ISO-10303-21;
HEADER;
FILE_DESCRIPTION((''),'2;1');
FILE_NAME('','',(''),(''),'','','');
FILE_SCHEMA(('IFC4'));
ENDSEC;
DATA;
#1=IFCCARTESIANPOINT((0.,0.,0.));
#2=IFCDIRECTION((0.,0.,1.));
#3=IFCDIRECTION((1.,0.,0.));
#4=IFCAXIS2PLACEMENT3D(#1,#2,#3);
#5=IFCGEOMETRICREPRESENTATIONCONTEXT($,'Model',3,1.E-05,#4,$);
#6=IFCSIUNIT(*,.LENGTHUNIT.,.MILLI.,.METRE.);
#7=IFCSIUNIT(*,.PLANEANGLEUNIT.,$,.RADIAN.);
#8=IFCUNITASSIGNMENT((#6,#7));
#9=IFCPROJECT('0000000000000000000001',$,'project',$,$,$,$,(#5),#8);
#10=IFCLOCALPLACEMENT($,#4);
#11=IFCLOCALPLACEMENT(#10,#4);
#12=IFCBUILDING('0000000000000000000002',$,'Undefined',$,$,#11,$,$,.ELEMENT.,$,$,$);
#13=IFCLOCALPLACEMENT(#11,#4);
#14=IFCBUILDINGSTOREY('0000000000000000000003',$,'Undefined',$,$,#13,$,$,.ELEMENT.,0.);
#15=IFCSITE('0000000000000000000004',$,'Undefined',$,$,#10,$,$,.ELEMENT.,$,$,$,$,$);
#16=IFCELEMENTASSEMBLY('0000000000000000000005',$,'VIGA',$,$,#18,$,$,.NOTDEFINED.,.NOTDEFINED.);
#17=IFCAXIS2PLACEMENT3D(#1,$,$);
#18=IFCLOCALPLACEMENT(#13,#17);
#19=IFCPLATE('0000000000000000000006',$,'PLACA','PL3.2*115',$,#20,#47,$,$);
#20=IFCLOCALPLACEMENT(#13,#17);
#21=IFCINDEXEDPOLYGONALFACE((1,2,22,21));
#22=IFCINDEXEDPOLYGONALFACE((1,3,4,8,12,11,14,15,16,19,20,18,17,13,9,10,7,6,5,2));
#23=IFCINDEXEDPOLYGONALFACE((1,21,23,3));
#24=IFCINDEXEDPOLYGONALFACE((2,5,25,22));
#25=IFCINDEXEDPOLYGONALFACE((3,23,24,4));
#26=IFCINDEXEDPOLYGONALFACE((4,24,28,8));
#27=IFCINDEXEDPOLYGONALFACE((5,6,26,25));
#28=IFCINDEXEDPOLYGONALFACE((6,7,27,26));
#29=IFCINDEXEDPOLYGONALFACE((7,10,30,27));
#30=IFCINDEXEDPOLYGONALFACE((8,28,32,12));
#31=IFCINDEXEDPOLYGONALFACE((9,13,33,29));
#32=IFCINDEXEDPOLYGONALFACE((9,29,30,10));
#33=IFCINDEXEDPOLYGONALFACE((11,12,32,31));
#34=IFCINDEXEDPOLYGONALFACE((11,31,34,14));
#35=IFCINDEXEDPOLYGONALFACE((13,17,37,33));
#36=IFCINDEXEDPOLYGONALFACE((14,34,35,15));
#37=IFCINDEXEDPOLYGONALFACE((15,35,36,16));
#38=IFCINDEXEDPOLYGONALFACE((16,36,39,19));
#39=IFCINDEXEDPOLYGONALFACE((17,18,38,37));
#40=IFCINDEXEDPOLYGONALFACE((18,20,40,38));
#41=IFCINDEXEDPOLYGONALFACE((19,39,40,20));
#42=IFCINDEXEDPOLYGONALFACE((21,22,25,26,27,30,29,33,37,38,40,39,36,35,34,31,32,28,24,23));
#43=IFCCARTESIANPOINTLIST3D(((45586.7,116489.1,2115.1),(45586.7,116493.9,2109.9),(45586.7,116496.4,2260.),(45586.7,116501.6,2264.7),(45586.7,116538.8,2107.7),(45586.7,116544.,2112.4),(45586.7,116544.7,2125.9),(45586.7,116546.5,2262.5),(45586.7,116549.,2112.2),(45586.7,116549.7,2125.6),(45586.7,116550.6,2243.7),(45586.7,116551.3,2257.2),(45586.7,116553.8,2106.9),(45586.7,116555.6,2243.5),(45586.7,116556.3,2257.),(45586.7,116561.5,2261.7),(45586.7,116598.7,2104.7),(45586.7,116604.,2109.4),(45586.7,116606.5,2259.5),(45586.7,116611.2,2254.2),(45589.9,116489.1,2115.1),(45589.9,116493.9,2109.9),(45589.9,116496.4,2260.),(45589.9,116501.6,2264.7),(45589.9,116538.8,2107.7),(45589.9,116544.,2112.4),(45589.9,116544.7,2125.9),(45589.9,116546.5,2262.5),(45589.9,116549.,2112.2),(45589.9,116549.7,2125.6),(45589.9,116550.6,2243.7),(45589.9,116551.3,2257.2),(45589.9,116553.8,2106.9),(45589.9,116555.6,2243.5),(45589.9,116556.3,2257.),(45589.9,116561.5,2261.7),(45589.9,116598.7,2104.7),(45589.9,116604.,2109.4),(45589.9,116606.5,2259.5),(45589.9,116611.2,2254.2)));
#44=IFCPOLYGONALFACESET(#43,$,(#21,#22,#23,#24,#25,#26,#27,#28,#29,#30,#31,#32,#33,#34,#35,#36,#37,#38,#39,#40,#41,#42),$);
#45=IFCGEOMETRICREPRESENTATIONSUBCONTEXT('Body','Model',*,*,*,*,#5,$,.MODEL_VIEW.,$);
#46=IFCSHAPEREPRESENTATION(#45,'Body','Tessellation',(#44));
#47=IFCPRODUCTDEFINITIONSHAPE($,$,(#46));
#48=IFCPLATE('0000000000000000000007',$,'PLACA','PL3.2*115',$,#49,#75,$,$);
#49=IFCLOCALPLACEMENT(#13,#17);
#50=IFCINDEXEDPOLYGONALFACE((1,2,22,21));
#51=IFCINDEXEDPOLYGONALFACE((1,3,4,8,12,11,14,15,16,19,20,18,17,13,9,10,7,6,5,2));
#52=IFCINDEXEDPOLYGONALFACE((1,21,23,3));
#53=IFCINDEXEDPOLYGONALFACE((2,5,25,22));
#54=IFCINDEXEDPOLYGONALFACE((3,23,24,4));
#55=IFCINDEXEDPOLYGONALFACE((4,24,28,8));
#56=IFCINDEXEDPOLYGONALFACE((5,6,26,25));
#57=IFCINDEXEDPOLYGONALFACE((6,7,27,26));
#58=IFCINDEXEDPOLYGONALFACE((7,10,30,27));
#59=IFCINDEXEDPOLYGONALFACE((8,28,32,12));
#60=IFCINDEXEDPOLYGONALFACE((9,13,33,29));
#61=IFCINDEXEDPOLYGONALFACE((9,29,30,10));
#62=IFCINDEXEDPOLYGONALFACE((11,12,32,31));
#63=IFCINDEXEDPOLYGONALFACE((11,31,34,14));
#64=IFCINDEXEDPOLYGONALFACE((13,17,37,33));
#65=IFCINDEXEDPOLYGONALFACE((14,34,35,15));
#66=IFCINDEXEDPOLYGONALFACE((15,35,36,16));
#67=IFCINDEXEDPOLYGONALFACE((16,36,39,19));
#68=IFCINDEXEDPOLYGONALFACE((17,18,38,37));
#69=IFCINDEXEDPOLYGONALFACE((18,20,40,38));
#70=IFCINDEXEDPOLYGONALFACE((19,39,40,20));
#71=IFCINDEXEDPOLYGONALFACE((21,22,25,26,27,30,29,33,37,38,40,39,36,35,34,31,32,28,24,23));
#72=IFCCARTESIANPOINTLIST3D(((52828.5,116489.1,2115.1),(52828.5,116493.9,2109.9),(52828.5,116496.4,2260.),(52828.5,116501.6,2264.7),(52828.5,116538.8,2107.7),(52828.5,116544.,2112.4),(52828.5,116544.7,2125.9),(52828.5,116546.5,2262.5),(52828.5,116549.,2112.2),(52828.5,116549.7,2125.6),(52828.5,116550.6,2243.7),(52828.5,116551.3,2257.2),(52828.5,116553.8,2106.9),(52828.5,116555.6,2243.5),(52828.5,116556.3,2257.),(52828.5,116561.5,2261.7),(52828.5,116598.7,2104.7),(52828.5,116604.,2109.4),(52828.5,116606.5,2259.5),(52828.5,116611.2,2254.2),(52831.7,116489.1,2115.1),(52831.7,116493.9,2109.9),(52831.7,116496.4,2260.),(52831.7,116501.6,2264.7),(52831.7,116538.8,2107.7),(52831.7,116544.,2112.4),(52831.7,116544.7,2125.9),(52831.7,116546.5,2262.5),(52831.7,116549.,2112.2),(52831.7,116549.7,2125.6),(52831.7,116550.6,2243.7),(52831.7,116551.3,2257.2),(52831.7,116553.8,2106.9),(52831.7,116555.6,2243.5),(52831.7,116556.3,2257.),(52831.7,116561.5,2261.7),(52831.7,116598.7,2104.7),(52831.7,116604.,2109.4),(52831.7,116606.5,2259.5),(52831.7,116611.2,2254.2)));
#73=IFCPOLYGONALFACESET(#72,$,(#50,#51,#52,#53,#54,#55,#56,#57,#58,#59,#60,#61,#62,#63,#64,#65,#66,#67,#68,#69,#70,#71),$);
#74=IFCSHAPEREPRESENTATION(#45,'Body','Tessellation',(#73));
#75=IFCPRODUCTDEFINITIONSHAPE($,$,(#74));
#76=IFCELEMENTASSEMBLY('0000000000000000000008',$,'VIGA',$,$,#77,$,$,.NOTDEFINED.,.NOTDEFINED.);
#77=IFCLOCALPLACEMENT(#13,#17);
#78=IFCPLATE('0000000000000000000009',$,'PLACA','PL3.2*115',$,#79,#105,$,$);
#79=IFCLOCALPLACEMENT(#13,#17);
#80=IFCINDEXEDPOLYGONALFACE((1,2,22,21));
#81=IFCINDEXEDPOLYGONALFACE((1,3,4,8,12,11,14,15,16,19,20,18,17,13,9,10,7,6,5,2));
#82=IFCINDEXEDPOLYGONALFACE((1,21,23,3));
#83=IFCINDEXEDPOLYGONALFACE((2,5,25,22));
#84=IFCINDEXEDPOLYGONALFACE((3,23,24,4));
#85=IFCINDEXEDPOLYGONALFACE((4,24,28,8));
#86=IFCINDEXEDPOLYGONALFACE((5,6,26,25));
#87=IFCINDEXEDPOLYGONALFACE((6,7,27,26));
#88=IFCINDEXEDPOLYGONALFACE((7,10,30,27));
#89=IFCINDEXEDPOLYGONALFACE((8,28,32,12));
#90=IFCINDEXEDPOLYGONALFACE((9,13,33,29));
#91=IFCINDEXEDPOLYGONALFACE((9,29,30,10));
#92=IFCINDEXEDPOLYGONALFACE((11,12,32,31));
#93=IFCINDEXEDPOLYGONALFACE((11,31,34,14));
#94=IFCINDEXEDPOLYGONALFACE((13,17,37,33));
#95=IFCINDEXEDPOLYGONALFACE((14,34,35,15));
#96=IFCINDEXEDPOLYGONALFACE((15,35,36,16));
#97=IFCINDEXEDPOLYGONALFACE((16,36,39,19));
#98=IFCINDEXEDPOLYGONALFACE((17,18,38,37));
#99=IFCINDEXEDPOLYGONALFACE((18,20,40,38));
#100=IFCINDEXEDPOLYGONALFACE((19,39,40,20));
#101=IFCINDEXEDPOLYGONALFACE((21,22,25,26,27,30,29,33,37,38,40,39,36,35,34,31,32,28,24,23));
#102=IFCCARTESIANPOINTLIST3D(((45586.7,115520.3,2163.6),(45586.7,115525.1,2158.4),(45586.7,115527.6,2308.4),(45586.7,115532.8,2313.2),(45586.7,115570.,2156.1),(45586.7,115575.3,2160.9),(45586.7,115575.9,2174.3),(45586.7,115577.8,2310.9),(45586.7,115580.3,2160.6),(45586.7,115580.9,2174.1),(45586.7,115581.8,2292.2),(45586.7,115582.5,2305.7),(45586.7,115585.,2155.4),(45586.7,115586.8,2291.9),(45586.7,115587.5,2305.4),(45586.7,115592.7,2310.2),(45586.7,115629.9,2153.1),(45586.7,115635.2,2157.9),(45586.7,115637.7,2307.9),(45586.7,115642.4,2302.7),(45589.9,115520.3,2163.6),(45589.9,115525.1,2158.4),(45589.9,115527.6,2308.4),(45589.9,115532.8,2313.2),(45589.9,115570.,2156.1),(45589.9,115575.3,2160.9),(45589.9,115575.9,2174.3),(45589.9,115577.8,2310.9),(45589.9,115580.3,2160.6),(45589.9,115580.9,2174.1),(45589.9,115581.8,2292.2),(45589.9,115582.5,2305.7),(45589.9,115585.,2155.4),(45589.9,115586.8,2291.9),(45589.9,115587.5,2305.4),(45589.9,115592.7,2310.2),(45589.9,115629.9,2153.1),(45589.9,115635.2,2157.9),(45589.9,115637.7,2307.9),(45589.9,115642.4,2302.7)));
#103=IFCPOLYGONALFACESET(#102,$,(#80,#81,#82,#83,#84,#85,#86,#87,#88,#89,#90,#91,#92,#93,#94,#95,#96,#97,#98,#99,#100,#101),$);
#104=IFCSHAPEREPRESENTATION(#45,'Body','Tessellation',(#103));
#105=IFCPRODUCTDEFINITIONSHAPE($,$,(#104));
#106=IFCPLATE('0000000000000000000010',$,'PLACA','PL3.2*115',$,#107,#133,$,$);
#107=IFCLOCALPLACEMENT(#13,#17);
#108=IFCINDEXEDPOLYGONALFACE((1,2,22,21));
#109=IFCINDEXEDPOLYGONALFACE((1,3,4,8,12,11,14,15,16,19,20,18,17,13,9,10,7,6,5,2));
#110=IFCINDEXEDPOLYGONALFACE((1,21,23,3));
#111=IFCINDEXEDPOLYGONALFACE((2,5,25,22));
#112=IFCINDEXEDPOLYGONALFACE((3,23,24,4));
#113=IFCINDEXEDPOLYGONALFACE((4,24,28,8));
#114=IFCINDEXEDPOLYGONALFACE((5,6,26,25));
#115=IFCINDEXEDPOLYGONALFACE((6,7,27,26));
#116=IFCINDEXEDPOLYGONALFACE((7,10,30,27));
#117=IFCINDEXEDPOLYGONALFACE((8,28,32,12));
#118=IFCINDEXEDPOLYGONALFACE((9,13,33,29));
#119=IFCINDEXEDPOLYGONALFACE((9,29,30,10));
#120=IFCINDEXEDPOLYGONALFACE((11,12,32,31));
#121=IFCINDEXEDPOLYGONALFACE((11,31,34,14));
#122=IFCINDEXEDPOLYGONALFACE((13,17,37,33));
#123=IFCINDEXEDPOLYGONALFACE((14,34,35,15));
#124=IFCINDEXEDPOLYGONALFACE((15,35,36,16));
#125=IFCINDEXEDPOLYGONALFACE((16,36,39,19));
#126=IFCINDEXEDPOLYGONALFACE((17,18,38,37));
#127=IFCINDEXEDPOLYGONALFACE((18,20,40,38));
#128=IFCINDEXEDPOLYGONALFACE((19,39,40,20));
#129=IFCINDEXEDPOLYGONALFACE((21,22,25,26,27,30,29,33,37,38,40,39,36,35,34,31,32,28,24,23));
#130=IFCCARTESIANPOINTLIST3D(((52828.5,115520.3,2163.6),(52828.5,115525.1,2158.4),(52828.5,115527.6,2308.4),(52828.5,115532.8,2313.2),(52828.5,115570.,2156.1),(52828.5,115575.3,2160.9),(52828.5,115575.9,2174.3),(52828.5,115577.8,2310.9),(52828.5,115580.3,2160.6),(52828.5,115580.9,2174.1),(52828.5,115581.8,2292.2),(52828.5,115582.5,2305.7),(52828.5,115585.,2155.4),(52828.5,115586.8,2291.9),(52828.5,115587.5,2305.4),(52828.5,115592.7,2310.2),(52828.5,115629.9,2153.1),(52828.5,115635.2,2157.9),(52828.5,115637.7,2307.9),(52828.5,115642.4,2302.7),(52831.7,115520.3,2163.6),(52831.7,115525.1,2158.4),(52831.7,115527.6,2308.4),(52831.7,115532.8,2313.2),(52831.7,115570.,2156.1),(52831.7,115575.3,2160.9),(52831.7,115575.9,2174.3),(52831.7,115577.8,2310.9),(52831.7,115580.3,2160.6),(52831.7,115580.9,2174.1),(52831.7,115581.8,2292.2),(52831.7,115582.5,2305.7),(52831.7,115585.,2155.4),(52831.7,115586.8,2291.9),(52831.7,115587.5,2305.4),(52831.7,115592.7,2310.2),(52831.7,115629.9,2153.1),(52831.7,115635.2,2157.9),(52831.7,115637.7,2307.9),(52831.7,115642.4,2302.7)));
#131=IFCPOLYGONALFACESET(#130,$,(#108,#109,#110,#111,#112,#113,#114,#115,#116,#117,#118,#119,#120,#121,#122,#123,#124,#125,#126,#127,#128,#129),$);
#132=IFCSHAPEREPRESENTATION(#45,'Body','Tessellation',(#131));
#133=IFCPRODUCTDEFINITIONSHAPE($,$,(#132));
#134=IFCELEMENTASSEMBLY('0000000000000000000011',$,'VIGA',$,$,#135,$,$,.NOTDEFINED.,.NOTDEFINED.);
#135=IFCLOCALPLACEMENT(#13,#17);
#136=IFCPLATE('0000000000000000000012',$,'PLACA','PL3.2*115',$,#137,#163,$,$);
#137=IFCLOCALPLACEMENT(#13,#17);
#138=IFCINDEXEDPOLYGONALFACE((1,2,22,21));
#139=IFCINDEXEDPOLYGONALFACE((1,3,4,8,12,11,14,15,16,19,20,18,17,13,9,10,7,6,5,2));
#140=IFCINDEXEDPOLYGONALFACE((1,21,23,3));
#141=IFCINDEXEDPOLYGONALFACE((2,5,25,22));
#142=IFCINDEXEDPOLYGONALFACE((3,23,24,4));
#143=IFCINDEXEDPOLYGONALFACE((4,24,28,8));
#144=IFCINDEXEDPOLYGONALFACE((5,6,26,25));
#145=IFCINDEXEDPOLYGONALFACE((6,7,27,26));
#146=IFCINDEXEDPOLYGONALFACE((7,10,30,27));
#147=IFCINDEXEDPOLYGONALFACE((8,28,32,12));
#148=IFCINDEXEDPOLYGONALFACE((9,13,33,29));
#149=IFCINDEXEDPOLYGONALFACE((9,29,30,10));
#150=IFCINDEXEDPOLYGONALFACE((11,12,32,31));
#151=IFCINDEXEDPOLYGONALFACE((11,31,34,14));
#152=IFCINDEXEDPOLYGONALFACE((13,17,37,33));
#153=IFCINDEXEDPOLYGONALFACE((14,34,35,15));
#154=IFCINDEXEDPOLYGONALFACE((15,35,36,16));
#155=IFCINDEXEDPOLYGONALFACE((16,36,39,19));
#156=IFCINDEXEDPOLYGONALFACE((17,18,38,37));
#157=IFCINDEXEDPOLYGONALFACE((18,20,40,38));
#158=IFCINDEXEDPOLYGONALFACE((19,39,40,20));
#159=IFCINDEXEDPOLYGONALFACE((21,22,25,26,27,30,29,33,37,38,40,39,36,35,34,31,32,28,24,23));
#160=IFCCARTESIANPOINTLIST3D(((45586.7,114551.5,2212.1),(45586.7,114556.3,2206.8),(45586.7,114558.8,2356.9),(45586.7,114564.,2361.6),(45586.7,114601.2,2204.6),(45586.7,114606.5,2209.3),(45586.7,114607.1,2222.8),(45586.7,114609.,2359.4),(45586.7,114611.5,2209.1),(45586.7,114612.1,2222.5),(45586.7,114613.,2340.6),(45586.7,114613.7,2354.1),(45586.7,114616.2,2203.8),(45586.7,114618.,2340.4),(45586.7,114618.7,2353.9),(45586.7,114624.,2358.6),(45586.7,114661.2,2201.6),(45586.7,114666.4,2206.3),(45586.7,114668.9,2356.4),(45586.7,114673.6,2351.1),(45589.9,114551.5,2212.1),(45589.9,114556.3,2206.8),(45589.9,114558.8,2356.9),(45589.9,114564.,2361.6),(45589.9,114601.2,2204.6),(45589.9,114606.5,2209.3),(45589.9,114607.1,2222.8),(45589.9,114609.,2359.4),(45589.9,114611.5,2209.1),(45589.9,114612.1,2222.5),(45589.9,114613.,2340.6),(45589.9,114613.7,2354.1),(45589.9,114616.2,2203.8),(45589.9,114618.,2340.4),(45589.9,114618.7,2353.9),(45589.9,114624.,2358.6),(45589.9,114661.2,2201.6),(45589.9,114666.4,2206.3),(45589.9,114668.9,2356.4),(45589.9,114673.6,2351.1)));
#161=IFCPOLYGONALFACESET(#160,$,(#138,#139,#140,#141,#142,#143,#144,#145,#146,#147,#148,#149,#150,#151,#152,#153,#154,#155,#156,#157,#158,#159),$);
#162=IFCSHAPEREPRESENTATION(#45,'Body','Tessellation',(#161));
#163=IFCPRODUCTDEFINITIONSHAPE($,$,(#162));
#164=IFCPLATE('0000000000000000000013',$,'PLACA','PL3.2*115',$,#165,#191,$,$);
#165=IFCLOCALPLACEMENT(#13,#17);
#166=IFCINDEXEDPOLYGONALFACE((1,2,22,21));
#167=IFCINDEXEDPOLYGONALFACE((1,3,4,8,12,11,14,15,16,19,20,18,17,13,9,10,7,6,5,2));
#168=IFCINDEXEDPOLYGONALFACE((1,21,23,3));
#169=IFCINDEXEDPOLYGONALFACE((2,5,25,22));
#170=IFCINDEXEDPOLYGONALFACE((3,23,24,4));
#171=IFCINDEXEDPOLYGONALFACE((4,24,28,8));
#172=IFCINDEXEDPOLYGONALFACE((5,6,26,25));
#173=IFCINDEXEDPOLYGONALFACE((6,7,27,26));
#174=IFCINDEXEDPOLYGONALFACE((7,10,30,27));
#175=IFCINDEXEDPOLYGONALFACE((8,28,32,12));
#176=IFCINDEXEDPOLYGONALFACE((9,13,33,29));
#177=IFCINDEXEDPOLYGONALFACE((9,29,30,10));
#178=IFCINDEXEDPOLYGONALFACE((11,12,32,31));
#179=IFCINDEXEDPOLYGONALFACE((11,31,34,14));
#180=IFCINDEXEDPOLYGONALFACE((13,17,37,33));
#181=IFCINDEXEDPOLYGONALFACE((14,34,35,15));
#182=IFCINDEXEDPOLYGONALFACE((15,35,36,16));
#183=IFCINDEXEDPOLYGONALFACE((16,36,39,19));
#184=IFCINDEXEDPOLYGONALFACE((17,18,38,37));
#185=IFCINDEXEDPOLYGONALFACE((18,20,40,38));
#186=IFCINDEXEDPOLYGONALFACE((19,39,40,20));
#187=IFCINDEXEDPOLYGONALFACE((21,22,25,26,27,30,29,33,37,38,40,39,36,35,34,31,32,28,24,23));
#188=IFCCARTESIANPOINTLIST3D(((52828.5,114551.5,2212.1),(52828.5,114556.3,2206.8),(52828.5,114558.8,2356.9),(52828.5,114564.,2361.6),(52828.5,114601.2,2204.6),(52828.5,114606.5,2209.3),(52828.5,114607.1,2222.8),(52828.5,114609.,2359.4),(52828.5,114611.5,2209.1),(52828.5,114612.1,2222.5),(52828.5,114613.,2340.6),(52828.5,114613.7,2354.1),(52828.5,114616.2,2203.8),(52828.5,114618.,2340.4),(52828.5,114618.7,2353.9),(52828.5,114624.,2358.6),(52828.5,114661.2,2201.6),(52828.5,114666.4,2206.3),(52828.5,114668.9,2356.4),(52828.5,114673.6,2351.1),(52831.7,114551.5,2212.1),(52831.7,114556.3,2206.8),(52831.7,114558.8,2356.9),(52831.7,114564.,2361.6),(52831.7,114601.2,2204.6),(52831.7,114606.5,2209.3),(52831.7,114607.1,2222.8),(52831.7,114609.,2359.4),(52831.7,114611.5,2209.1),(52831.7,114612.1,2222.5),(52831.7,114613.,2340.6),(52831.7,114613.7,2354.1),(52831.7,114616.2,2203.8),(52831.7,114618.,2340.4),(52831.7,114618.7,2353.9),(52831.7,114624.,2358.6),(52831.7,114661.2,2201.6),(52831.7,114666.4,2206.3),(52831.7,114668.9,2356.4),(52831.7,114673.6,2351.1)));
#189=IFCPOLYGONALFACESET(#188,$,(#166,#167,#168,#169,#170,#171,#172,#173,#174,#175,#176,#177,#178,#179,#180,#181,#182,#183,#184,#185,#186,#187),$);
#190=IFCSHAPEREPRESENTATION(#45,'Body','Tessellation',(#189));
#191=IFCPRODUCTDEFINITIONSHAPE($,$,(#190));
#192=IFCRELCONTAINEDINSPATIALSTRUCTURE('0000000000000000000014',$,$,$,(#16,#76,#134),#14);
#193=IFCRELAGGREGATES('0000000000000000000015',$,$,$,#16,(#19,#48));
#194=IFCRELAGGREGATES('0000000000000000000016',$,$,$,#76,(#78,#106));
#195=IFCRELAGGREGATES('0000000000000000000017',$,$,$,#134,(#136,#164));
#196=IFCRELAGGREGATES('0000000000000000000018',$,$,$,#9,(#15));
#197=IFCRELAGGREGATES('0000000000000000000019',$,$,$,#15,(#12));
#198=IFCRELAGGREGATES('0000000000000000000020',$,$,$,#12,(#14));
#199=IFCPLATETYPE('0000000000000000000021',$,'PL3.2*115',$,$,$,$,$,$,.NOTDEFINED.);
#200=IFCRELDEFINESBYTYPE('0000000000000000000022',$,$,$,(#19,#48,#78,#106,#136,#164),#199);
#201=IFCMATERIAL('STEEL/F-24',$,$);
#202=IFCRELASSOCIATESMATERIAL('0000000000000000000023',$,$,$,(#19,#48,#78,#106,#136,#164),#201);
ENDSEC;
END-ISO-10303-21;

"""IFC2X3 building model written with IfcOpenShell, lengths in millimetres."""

from ifc_helpers import new_model, si_unit, frame, origin_with_axes, place, context, subcontext, project, spatial, polyline, outline, extrude, material, type_object, element, aggregate, save


model = new_model("IFC2X3")

# Units and contexts
model_context = context("Model", 3, precision=1e-05, world=origin_with_axes())
body_context = subcontext(model_context, "Body", "Model", "MODEL_VIEW")
ifc_project = project(units=[si_unit("LENGTHUNIT", "METRE", prefix="MILLI"), si_unit("PLANEANGLEUNIT", "RADIAN")], contexts=[model_context])

# Site, building, storey
site_placement = place(None, origin_with_axes())
site = spatial("IfcSite", under=ifc_project, at=site_placement, Name="Undefined", CompositionType="ELEMENT")
building_placement = place(site_placement, origin_with_axes())
building = spatial("IfcBuilding", under=site, at=building_placement, Name="Undefined", CompositionType="ELEMENT")
storey_placement = place(building_placement, origin_with_axes())
storey = spatial("IfcBuildingStorey", under=building, at=storey_placement, Name="Undefined", CompositionType="ELEMENT", Elevation=0.0)

# Element assemblies, plates
ifc_material_1 = material(Name="STEEL/F-24")
plate_type_1 = type_object("IfcPlateType", Name="PL3.2*115", PredefinedType="NOTDEFINED")
assembly_1_placement = place(storey_placement, origin_with_axes())
assembly_1 = element("IfcElementAssembly", 1, at=assembly_1_placement, inside=storey, Name="VIGA", AssemblyPlace="NOTDEFINED", PredefinedType="NOTDEFINED")
plate_1_placement = place(assembly_1_placement, frame((45588.3, 116611.5, 2259.2), z_axis=(1.0, 0.0, 0.0), x_axis=(0.0, -0.998752, 0.04995)))
plate_1 = element("IfcPlate", 2, at=plate_1_placement, type_object=plate_type_1, material=ifc_material_1, Name="PLACA", Description="PL3.2*115", context=body_context, shape_type="SweptSolid", body=[
    extrude(outline(polyline([(0.0, 5.0), (5.0, 0.0), (50.0, 0.0), (55.0, 5.0), (55.0, 18.5), (60.0, 18.5), (60.0, 5.0), (65.0, 0.0), (110.0, 0.0), (115.0, 5.0), (115.0, 150.0), (110.0, 155.0), (65.0, 155.0), (60.0, 150.0), (60.0, 136.5), (55.0, 136.5), (55.0, 150.0), (50.0, 155.0), (5.0, 155.0), (0.0, 150.0), (0.0, 5.0)])), frame((0.0, 0.0, -1.6), z_axis=(0.0, 0.0, 1.0), x_axis=(1.0, 0.0, 0.0)), (0.0, 0.0, 1.0), 3.2),
])
plate_2_placement = place(assembly_1_placement, frame((52830.1, 116611.5, 2259.2), z_axis=(1.0, 0.0, 0.0), x_axis=(0.0, -0.998752, 0.04995)))
plate_2 = element("IfcPlate", 3, at=plate_2_placement, type_object=plate_type_1, material=ifc_material_1, Name="PLACA", Description="PL3.2*115", context=body_context, shape_type="SweptSolid", body=[
    extrude(outline(polyline([(0.0, 5.0), (5.0, 0.0), (50.0, 0.0), (55.0, 5.0), (55.0, 18.5), (60.0, 18.5), (60.0, 5.0), (65.0, 0.0), (110.0, 0.0), (115.0, 5.0), (115.0, 150.0), (110.0, 155.0), (65.0, 155.0), (60.0, 150.0), (60.0, 136.5), (55.0, 136.5), (55.0, 150.0), (50.0, 155.0), (5.0, 155.0), (0.0, 150.0), (0.0, 5.0)])), frame((0.0, 0.0, -1.6), z_axis=(0.0, 0.0, 1.0), x_axis=(1.0, 0.0, 0.0)), (0.0, 0.0, 1.0), 3.2),
])
assembly_2_placement = place(storey_placement, origin_with_axes())
assembly_2 = element("IfcElementAssembly", 4, at=assembly_2_placement, inside=storey, Name="VIGA", AssemblyPlace="NOTDEFINED", PredefinedType="NOTDEFINED")
plate_3_placement = place(assembly_2_placement, frame((45588.3, 115642.7, 2307.7), z_axis=(1.0, 0.0, 0.0), x_axis=(0.0, -0.998752, 0.04995)))
plate_3 = element("IfcPlate", 5, at=plate_3_placement, type_object=plate_type_1, material=ifc_material_1, Name="PLACA", Description="PL3.2*115", context=body_context, shape_type="SweptSolid", body=[
    extrude(outline(polyline([(0.0, 5.0), (5.0, 0.0), (50.0, 0.0), (55.0, 5.0), (55.0, 18.5), (60.0, 18.5), (60.0, 5.0), (65.0, 0.0), (110.0, 0.0), (115.0, 5.0), (115.0, 150.0), (110.0, 155.0), (65.0, 155.0), (60.0, 150.0), (60.0, 136.5), (55.0, 136.5), (55.0, 150.0), (50.0, 155.0), (5.0, 155.0), (0.0, 150.0), (0.0, 5.0)])), frame((0.0, 0.0, -1.6), z_axis=(0.0, 0.0, 1.0), x_axis=(1.0, 0.0, 0.0)), (0.0, 0.0, 1.0), 3.2),
])
plate_4_placement = place(assembly_2_placement, frame((52830.1, 115642.7, 2307.7), z_axis=(1.0, 0.0, 0.0), x_axis=(0.0, -0.998752, 0.04995)))
plate_4 = element("IfcPlate", 6, at=plate_4_placement, type_object=plate_type_1, material=ifc_material_1, Name="PLACA", Description="PL3.2*115", context=body_context, shape_type="SweptSolid", body=[
    extrude(outline(polyline([(0.0, 5.0), (5.0, 0.0), (50.0, 0.0), (55.0, 5.0), (55.0, 18.5), (60.0, 18.5), (60.0, 5.0), (65.0, 0.0), (110.0, 0.0), (115.0, 5.0), (115.0, 150.0), (110.0, 155.0), (65.0, 155.0), (60.0, 150.0), (60.0, 136.5), (55.0, 136.5), (55.0, 150.0), (50.0, 155.0), (5.0, 155.0), (0.0, 150.0), (0.0, 5.0)])), frame((0.0, 0.0, -1.6), z_axis=(0.0, 0.0, 1.0), x_axis=(1.0, 0.0, 0.0)), (0.0, 0.0, 1.0), 3.2),
])
assembly_3_placement = place(storey_placement, origin_with_axes())
assembly_3 = element("IfcElementAssembly", 7, at=assembly_3_placement, inside=storey, Name="VIGA", AssemblyPlace="NOTDEFINED", PredefinedType="NOTDEFINED")
plate_5_placement = place(assembly_3_placement, frame((45588.3, 114673.9, 2356.1), z_axis=(1.0, 0.0, 0.0), x_axis=(0.0, -0.998752, 0.04995)))
plate_5 = element("IfcPlate", 8, at=plate_5_placement, type_object=plate_type_1, material=ifc_material_1, Name="PLACA", Description="PL3.2*115", context=body_context, shape_type="SweptSolid", body=[
    extrude(outline(polyline([(0.0, 5.0), (5.0, 0.0), (50.0, 0.0), (55.0, 5.0), (55.0, 18.5), (60.0, 18.5), (60.0, 5.0), (65.0, 0.0), (110.0, 0.0), (115.0, 5.0), (115.0, 150.0), (110.0, 155.0), (65.0, 155.0), (60.0, 150.0), (60.0, 136.5), (55.0, 136.5), (55.0, 150.0), (50.0, 155.0), (5.0, 155.0), (0.0, 150.0), (0.0, 5.0)])), frame((0.0, 0.0, -1.6), z_axis=(0.0, 0.0, 1.0), x_axis=(1.0, 0.0, 0.0)), (0.0, 0.0, 1.0), 3.2),
])
plate_6_placement = place(assembly_3_placement, frame((52830.1, 114673.9, 2356.1), z_axis=(1.0, 0.0, 0.0), x_axis=(0.0, -0.998752, 0.04995)))
plate_6 = element("IfcPlate", 9, at=plate_6_placement, type_object=plate_type_1, material=ifc_material_1, Name="PLACA", Description="PL3.2*115", context=body_context, shape_type="SweptSolid", body=[
    extrude(outline(polyline([(0.0, 5.0), (5.0, 0.0), (50.0, 0.0), (55.0, 5.0), (55.0, 18.5), (60.0, 18.5), (60.0, 5.0), (65.0, 0.0), (110.0, 0.0), (115.0, 5.0), (115.0, 150.0), (110.0, 155.0), (65.0, 155.0), (60.0, 150.0), (60.0, 136.5), (55.0, 136.5), (55.0, 150.0), (50.0, 155.0), (5.0, 155.0), (0.0, 150.0), (0.0, 5.0)])), frame((0.0, 0.0, -1.6), z_axis=(0.0, 0.0, 1.0), x_axis=(1.0, 0.0, 0.0)), (0.0, 0.0, 1.0), 3.2),
])

aggregate(assembly_1, [plate_1, plate_2])
aggregate(assembly_2, [plate_3, plate_4])
aggregate(assembly_3, [plate_5, plate_6])

save(model, "model.ifc")
